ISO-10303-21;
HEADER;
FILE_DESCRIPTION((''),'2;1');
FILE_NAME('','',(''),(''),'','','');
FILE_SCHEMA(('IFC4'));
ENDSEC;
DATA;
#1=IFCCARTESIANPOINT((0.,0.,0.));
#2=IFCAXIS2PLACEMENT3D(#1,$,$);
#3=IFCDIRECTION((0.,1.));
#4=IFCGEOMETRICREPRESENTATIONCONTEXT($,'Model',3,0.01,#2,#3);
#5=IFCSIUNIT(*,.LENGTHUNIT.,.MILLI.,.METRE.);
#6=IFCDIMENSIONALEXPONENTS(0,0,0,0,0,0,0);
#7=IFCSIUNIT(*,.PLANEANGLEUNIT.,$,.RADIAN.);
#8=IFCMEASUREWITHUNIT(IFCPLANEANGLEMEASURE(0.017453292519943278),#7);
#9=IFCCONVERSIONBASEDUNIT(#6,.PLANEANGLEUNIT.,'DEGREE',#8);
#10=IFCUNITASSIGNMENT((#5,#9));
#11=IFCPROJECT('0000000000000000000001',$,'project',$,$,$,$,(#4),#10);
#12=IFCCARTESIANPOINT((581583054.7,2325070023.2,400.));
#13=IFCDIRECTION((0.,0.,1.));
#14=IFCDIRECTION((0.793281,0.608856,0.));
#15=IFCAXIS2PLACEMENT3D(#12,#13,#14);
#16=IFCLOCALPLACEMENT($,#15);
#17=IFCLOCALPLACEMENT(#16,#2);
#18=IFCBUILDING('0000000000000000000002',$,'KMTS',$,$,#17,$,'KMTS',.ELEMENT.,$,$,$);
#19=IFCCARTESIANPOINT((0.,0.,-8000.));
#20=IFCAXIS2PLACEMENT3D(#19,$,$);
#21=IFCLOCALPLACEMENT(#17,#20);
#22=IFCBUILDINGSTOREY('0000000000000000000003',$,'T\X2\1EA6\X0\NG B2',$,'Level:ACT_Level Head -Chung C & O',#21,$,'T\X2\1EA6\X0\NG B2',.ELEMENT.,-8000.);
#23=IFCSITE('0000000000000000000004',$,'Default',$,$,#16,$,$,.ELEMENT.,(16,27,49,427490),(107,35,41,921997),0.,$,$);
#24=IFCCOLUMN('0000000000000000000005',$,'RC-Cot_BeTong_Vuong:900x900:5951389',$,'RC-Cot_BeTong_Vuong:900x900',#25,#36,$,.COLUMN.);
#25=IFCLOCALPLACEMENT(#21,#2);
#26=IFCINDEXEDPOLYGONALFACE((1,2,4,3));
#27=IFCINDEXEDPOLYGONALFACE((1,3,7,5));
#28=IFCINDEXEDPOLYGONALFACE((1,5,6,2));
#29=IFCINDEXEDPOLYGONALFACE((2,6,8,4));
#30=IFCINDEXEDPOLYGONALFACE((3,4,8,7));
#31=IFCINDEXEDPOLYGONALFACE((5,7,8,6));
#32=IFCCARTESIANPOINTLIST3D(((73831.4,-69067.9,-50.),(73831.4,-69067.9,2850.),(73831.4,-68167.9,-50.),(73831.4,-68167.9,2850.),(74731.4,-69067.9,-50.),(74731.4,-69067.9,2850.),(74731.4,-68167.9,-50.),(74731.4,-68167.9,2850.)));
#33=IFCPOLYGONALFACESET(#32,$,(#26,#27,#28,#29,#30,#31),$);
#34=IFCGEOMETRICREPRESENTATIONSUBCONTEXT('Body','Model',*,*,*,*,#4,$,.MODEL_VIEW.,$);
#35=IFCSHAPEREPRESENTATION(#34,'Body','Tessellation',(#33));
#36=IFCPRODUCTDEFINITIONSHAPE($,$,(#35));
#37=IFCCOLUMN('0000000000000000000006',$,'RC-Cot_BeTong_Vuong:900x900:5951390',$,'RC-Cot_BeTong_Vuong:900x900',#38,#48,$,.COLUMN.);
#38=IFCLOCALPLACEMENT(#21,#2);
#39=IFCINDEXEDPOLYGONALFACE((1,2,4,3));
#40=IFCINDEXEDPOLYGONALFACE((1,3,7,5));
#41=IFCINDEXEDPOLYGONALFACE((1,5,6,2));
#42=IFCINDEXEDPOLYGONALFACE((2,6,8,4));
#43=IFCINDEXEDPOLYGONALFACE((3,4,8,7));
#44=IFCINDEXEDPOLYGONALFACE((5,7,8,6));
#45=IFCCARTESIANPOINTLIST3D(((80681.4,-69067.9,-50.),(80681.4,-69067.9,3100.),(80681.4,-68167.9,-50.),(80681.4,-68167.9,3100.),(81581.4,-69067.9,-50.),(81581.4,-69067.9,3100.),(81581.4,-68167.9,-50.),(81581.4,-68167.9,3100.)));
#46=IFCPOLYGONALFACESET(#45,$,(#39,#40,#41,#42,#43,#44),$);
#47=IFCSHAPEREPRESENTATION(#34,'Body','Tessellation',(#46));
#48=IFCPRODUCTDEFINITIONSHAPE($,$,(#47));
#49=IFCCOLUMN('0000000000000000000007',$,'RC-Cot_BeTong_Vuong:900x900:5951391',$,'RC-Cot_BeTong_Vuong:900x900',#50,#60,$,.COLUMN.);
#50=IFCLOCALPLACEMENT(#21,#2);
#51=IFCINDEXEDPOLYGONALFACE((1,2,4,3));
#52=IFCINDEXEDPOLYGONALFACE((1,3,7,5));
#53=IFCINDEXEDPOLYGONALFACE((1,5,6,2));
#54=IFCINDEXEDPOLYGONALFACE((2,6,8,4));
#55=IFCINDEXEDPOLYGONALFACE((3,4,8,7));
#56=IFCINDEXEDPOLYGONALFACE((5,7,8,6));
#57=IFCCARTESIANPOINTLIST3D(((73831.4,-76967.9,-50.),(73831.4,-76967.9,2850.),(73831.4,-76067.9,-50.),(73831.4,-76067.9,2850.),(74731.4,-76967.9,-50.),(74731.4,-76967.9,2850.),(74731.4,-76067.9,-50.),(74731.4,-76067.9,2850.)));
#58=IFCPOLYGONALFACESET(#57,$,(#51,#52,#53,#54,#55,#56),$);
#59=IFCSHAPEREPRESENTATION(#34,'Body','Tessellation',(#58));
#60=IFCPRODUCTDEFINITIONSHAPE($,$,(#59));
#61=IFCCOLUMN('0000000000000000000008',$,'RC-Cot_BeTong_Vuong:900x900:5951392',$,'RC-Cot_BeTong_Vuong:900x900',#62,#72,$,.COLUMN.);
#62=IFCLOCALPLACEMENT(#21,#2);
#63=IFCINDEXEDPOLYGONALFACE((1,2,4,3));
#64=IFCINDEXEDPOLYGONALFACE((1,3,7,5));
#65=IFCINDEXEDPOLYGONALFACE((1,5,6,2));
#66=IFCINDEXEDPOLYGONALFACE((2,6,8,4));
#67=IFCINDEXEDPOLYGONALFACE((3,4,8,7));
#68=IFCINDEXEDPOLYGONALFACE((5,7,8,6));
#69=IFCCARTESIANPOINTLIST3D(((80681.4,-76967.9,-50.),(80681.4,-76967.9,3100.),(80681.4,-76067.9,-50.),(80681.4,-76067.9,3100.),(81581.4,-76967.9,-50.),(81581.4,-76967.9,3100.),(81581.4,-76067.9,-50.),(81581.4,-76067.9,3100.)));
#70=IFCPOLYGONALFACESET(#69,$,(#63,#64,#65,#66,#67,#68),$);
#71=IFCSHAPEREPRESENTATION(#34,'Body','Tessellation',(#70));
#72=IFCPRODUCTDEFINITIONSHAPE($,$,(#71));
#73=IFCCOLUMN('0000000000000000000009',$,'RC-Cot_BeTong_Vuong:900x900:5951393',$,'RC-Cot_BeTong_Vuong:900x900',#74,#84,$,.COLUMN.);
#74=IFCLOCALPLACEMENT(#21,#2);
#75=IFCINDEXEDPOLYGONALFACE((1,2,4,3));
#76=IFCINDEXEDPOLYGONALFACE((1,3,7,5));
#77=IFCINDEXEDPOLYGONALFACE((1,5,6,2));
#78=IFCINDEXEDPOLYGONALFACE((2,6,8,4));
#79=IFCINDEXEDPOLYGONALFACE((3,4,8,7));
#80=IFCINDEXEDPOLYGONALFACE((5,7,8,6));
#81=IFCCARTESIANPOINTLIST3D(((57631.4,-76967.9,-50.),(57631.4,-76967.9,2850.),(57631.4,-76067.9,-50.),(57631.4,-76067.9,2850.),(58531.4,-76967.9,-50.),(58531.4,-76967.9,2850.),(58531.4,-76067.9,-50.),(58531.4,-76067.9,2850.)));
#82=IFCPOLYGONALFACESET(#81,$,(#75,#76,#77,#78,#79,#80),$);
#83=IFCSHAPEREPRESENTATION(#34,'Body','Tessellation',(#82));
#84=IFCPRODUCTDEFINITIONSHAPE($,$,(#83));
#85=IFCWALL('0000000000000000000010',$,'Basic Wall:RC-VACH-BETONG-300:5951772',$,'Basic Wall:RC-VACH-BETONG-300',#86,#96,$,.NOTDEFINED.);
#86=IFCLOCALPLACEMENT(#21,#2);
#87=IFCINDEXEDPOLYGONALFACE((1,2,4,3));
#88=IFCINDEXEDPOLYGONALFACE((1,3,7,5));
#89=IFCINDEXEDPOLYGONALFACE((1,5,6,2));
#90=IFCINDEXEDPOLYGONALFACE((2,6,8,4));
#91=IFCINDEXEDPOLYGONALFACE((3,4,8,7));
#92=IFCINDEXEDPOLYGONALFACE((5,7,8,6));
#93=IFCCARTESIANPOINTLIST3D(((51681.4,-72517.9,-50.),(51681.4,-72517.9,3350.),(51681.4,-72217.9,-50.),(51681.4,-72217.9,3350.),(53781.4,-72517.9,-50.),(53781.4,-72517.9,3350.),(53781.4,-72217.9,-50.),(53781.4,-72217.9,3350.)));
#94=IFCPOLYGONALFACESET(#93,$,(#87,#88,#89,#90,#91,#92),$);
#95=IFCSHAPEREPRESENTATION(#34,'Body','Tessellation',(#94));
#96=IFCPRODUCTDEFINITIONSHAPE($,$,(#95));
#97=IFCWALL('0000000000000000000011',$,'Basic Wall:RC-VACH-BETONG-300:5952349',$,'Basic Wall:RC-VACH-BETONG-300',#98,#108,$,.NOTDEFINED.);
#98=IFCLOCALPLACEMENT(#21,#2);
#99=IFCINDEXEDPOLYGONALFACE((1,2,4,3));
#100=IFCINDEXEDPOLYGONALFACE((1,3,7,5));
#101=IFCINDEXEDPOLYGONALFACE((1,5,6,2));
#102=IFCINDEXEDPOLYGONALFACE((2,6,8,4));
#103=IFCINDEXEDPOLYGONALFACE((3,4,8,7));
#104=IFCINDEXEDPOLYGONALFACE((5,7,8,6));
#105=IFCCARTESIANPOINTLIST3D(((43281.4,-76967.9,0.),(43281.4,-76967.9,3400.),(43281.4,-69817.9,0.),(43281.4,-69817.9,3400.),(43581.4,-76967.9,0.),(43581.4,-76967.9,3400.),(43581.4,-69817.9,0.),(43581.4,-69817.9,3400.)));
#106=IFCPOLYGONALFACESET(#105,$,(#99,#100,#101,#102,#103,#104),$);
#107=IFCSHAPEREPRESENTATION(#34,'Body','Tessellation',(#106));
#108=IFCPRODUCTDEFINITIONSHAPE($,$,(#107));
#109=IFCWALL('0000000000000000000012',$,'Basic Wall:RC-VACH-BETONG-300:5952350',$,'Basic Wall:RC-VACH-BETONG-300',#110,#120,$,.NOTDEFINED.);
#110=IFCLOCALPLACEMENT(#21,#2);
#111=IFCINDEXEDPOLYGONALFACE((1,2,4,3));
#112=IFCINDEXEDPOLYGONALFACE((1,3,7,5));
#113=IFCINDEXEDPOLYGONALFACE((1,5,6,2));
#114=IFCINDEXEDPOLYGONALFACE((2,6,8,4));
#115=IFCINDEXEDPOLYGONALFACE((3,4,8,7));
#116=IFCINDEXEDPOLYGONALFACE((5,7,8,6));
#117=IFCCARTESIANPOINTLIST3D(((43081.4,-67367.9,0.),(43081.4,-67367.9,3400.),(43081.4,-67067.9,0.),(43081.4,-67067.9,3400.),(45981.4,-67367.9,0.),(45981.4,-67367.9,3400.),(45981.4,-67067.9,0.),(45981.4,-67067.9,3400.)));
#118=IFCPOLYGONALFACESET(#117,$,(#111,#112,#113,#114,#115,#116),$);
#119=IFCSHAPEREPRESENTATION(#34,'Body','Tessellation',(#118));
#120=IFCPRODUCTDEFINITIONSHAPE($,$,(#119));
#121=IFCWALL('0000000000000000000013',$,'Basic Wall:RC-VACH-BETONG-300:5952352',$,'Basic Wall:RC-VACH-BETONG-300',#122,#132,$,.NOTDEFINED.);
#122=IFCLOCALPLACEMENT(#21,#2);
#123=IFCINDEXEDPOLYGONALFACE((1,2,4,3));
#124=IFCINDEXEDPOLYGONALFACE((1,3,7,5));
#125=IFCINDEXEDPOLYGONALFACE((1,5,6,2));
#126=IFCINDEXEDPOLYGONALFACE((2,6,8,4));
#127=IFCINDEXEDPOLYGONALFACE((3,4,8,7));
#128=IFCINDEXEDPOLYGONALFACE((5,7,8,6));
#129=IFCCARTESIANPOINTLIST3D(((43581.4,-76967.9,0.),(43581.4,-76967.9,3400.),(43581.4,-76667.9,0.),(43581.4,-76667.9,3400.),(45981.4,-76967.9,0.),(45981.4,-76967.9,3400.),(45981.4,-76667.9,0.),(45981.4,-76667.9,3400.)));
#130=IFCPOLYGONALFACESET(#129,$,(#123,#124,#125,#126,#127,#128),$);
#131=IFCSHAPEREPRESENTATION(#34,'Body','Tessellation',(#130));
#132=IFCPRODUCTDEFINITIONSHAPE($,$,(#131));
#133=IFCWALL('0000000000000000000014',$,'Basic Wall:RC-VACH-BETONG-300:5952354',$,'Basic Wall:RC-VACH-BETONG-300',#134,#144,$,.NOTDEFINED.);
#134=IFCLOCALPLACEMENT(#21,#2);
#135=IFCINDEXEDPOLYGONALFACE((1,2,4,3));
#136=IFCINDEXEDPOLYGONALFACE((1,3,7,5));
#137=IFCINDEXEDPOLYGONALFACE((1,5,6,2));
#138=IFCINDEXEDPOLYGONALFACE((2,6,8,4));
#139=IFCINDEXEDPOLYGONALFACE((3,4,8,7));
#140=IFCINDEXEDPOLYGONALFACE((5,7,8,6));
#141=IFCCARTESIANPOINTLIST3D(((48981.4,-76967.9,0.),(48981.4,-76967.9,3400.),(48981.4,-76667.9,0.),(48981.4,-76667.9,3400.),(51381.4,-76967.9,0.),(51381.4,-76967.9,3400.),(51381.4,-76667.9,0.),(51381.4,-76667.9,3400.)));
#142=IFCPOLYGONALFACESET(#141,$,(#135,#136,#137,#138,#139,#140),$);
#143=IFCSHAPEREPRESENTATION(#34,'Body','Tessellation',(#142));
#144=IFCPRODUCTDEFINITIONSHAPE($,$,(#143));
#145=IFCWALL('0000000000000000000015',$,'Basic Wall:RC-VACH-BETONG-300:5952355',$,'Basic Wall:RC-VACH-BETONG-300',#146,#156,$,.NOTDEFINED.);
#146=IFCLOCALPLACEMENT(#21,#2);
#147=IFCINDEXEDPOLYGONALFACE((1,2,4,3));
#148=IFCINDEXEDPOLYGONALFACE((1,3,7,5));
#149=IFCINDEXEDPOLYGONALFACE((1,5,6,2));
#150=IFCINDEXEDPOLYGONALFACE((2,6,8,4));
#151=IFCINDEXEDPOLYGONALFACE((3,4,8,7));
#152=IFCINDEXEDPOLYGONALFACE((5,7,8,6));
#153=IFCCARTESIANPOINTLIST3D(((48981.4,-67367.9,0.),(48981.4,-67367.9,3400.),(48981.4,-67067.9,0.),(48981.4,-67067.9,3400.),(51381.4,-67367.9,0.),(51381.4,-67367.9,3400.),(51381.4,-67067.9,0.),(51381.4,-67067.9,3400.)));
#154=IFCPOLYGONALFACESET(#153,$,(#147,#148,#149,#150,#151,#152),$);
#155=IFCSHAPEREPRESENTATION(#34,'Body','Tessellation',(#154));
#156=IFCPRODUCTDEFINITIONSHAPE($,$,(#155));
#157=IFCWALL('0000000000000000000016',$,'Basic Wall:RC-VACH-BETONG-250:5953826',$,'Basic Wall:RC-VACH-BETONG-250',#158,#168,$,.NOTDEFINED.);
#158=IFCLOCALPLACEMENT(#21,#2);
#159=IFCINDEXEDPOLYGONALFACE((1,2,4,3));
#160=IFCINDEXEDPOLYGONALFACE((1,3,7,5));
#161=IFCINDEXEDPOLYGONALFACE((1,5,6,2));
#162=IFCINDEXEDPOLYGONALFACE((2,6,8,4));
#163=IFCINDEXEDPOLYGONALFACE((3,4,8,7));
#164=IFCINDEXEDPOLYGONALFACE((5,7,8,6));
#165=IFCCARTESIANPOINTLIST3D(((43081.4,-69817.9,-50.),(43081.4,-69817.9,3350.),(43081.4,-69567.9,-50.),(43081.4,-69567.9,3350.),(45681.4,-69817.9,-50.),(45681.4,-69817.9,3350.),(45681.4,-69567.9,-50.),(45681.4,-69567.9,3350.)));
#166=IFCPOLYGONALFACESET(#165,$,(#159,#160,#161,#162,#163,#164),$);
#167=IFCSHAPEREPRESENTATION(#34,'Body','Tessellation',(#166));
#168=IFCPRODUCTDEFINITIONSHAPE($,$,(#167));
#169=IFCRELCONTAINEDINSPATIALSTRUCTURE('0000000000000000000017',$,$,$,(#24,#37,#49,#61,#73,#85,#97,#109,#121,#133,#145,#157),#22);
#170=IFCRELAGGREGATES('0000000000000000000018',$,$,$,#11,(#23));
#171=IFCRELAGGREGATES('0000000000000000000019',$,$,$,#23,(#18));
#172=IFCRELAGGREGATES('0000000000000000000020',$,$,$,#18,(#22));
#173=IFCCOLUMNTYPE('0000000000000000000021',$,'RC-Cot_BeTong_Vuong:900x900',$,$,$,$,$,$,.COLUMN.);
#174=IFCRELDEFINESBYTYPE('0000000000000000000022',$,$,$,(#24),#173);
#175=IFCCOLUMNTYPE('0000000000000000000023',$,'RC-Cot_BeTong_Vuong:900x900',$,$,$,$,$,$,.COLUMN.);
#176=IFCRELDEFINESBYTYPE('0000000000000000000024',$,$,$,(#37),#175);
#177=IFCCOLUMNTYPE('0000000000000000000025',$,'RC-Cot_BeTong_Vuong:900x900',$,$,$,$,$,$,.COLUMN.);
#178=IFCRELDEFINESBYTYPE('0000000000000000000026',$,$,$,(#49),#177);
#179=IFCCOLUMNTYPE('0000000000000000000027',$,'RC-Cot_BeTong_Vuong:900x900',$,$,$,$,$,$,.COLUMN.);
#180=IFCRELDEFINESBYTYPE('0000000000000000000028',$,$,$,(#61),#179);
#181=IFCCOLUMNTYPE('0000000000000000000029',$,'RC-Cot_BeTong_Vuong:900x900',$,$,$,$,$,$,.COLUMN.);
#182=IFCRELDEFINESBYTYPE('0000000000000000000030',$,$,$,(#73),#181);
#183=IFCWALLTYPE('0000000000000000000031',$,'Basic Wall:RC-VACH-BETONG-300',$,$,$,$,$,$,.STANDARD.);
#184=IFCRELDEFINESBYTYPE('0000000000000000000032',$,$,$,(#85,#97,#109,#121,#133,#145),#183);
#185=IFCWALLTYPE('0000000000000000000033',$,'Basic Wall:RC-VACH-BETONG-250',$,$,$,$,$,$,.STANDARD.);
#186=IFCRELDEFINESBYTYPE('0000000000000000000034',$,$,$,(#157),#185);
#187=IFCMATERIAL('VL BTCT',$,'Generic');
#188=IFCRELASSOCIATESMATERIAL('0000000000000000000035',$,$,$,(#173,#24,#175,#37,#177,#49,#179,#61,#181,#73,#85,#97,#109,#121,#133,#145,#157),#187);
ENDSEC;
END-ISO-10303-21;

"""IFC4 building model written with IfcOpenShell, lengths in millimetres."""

from ifc_helpers import new_model, entity, si_unit, converted_unit, direction, frame, origin, place, context, subcontext, project, spatial, indexed_curve, outline, extrude, source, transform, mapped, material, type_object, type_shapes, element, save


model = new_model("IFC4")

# Units and contexts
model_context = context("Model", 3, precision=0.01, world=origin(), true_north=direction((0.0, 1.0)))
body_context = subcontext(model_context, "Body", "Model", "MODEL_VIEW")
ifc_project = project(units=[si_unit("LENGTHUNIT", "METRE", prefix="MILLI"), converted_unit("PLANEANGLEUNIT", "DEGREE", entity("IfcPlaneAngleMeasure", 0.017453292519943278), si_unit("PLANEANGLEUNIT", "RADIAN"), dimensions=[0, 0, 0, 0, 0, 0, 0])], contexts=[model_context])

# Site, building, storey
site_placement = place(None, frame((581583054.7, 2325070023.2, 400.0), z_axis=(0.0, 0.0, 1.0), x_axis=(0.793281, 0.608856, 0.0)))
site = spatial("IfcSite", under=ifc_project, at=site_placement, Name="Default", CompositionType="ELEMENT", RefLatitude=(16, 27, 49, 427490), RefLongitude=(107, 35, 41, 921997), RefElevation=0.0)
building_placement = place(site_placement, origin())
building = spatial("IfcBuilding", under=site, at=building_placement, Name="KMTS", LongName="KMTS", CompositionType="ELEMENT")
storey_placement = place(building_placement, frame((0.0, 0.0, -8000.0)))
storey = spatial("IfcBuildingStorey", under=building, at=storey_placement, Name="TẦNG B2", ObjectType="Level:ACT_Level Head -Chung C & O", LongName="TẦNG B2", CompositionType="ELEMENT", Elevation=-8000.0)

# Columns
ifc_material = material(Name="VL BTCT", Category="Generic")
column_type_1 = type_object("IfcColumnType", Name="RC-Cot_BeTong_Vuong:900x900", PredefinedType="COLUMN", material=ifc_material)
shared_shape_1 = source(origin(), body_context, "Body", "SweptSolid", [
    extrude(outline(indexed_curve([(-450.0, -450.0), (450.0, -450.0), (450.0, 450.0), (-450.0, 450.0), (-450.0, -450.0)], self_intersect=False)), frame((74281.4, -68617.9, -8050.0), z_axis=(0.0, 0.0, 1.0), x_axis=(-1.0, 0.0, 0.0)), (0.0, 0.0, 1.0), 2900.0),
])
type_shapes(column_type_1, [shared_shape_1])
column_1_placement = place(storey_placement, frame((0.0, 0.0, 8000.0)))
element("IfcColumn", 1, at=column_1_placement, inside=storey, type_object=column_type_1, material=ifc_material, Name="RC-Cot_BeTong_Vuong:900x900:5951389", ObjectType="RC-Cot_BeTong_Vuong:900x900", PredefinedType="COLUMN", context=body_context, shape_type="MappedRepresentation", body=[
    mapped(shared_shape_1, transform((0.0, 0.0, 0.0), scale=1.0)),
])
column_type_2 = type_object("IfcColumnType", Name="RC-Cot_BeTong_Vuong:900x900", PredefinedType="COLUMN", material=ifc_material)
shared_shape_2 = source(origin(), body_context, "Body", "SweptSolid", [
    extrude(outline(indexed_curve([(-450.0, -450.0), (450.0, -450.0), (450.0, 450.0), (-450.0, 450.0), (-450.0, -450.0)], self_intersect=False)), frame((81131.4, -68617.9, -8050.0), z_axis=(0.0, 0.0, 1.0), x_axis=(-1.0, 0.0, 0.0)), (0.0, 0.0, 1.0), 3150.0),
])
type_shapes(column_type_2, [shared_shape_2])
column_2_placement = place(storey_placement, frame((0.0, 0.0, 8000.0)))
element("IfcColumn", 2, at=column_2_placement, inside=storey, type_object=column_type_2, material=ifc_material, Name="RC-Cot_BeTong_Vuong:900x900:5951390", ObjectType="RC-Cot_BeTong_Vuong:900x900", PredefinedType="COLUMN", context=body_context, shape_type="MappedRepresentation", body=[
    mapped(shared_shape_2, transform((0.0, 0.0, 0.0), scale=1.0)),
])
column_type_3 = type_object("IfcColumnType", Name="RC-Cot_BeTong_Vuong:900x900", PredefinedType="COLUMN", material=ifc_material)
shared_shape_3 = source(origin(), body_context, "Body", "SweptSolid", [
    extrude(outline(indexed_curve([(-450.0, -450.0), (450.0, -450.0), (450.0, 450.0), (-450.0, 450.0), (-450.0, -450.0)], self_intersect=False)), frame((74281.4, -76517.9, -8050.0), z_axis=(0.0, 0.0, 1.0), x_axis=(-1.0, 0.0, 0.0)), (0.0, 0.0, 1.0), 2900.0),
])
type_shapes(column_type_3, [shared_shape_3])
column_3_placement = place(storey_placement, frame((0.0, 0.0, 8000.0)))
element("IfcColumn", 3, at=column_3_placement, inside=storey, type_object=column_type_3, material=ifc_material, Name="RC-Cot_BeTong_Vuong:900x900:5951391", ObjectType="RC-Cot_BeTong_Vuong:900x900", PredefinedType="COLUMN", context=body_context, shape_type="MappedRepresentation", body=[
    mapped(shared_shape_3, transform((0.0, 0.0, 0.0), scale=1.0)),
])
column_type_4 = type_object("IfcColumnType", Name="RC-Cot_BeTong_Vuong:900x900", PredefinedType="COLUMN", material=ifc_material)
shared_shape_4 = source(origin(), body_context, "Body", "SweptSolid", [
    extrude(outline(indexed_curve([(-450.0, -450.0), (450.0, -450.0), (450.0, 450.0), (-450.0, 450.0), (-450.0, -450.0)], self_intersect=False)), frame((81131.4, -76517.9, -8050.0), z_axis=(0.0, 0.0, 1.0), x_axis=(-1.0, 0.0, 0.0)), (0.0, 0.0, 1.0), 3150.0),
])
type_shapes(column_type_4, [shared_shape_4])
column_4_placement = place(storey_placement, frame((0.0, 0.0, 8000.0)))
element("IfcColumn", 4, at=column_4_placement, inside=storey, type_object=column_type_4, material=ifc_material, Name="RC-Cot_BeTong_Vuong:900x900:5951392", ObjectType="RC-Cot_BeTong_Vuong:900x900", PredefinedType="COLUMN", context=body_context, shape_type="MappedRepresentation", body=[
    mapped(shared_shape_4, transform((0.0, 0.0, 0.0), scale=1.0)),
])
column_type_5 = type_object("IfcColumnType", Name="RC-Cot_BeTong_Vuong:900x900", PredefinedType="COLUMN", material=ifc_material)
shared_shape_5 = source(origin(), body_context, "Body", "SweptSolid", [
    extrude(outline(indexed_curve([(-450.0, -450.0), (450.0, -450.0), (450.0, 450.0), (-450.0, 450.0), (-450.0, -450.0)], self_intersect=False)), frame((58081.4, -76517.9, -8050.0), z_axis=(0.0, 0.0, 1.0), x_axis=(-1.0, 0.0, 0.0)), (0.0, 0.0, 1.0), 2900.0),
])
type_shapes(column_type_5, [shared_shape_5])
column_5_placement = place(storey_placement, frame((0.0, 0.0, 8000.0)))
element("IfcColumn", 5, at=column_5_placement, inside=storey, type_object=column_type_5, material=ifc_material, Name="RC-Cot_BeTong_Vuong:900x900:5951393", ObjectType="RC-Cot_BeTong_Vuong:900x900", PredefinedType="COLUMN", context=body_context, shape_type="MappedRepresentation", body=[
    mapped(shared_shape_5, transform((0.0, 0.0, 0.0), scale=1.0)),
])

# Walls
wall_type_1 = type_object("IfcWallType", Name="Basic Wall:RC-VACH-BETONG-300", PredefinedType="STANDARD")
wall_1_placement = place(storey_placement, frame((53781.4, -72367.9, -50.0), z_axis=(0.0, 0.0, 1.0), x_axis=(-1.0, 0.0, 0.0)))
element("IfcWall", 6, at=wall_1_placement, inside=storey, type_object=wall_type_1, material=ifc_material, Name="Basic Wall:RC-VACH-BETONG-300:5951772", ObjectType="Basic Wall:RC-VACH-BETONG-300", PredefinedType="NOTDEFINED", context=body_context, shape_type="SweptSolid", body=[
    extrude(outline(indexed_curve([(2100.0, 150.0), (0.0, 150.0), (0.0, -150.0), (2100.0, -150.0), (2100.0, 150.0)], self_intersect=False)), origin(), (0.0, 0.0, 1.0), 3400.0),
])
wall_2_placement = place(storey_placement, frame((43431.4, -69817.9, 0.0), z_axis=(0.0, 0.0, 1.0), x_axis=(0.0, -1.0, 0.0)))
element("IfcWall", 7, at=wall_2_placement, inside=storey, type_object=wall_type_1, material=ifc_material, Name="Basic Wall:RC-VACH-BETONG-300:5952349", ObjectType="Basic Wall:RC-VACH-BETONG-300", PredefinedType="NOTDEFINED", context=body_context, shape_type="SweptSolid", body=[
    extrude(outline(indexed_curve([(7150.0, 150.0), (0.0, 150.0), (0.0, -150.0), (7150.0, -150.0), (7150.0, 150.0)], self_intersect=False)), origin(), (0.0, 0.0, 1.0), 3400.0),
])
wall_3_placement = place(storey_placement, frame((45981.4, -67217.9, 0.0), z_axis=(0.0, 0.0, 1.0), x_axis=(-1.0, 0.0, 0.0)))
element("IfcWall", 8, at=wall_3_placement, inside=storey, type_object=wall_type_1, material=ifc_material, Name="Basic Wall:RC-VACH-BETONG-300:5952350", ObjectType="Basic Wall:RC-VACH-BETONG-300", PredefinedType="NOTDEFINED", context=body_context, shape_type="SweptSolid", body=[
    extrude(outline(indexed_curve([(2900.0, 150.0), (0.0, 150.0), (0.0, -150.0), (2900.0, -150.0), (2900.0, 150.0)], self_intersect=False)), origin(), (0.0, 0.0, 1.0), 3400.0),
])
wall_4_placement = place(storey_placement, frame((45981.4, -76817.9, 0.0), z_axis=(0.0, 0.0, 1.0), x_axis=(-1.0, 0.0, 0.0)))
element("IfcWall", 9, at=wall_4_placement, inside=storey, type_object=wall_type_1, material=ifc_material, Name="Basic Wall:RC-VACH-BETONG-300:5952352", ObjectType="Basic Wall:RC-VACH-BETONG-300", PredefinedType="NOTDEFINED", context=body_context, shape_type="SweptSolid", body=[
    extrude(outline(indexed_curve([(2400.0, 150.0), (0.0, 150.0), (0.0, -150.0), (2400.0, -150.0), (2400.0, 150.0)], self_intersect=False)), origin(), (0.0, 0.0, 1.0), 3400.0),
])
wall_5_placement = place(storey_placement, frame((51381.4, -76817.9, 0.0), z_axis=(0.0, 0.0, 1.0), x_axis=(-1.0, 0.0, 0.0)))
element("IfcWall", 10, at=wall_5_placement, inside=storey, type_object=wall_type_1, material=ifc_material, Name="Basic Wall:RC-VACH-BETONG-300:5952354", ObjectType="Basic Wall:RC-VACH-BETONG-300", PredefinedType="NOTDEFINED", context=body_context, shape_type="SweptSolid", body=[
    extrude(outline(indexed_curve([(2400.0, 150.0), (0.0, 150.0), (0.0, -150.0), (2400.0, -150.0), (2400.0, 150.0)], self_intersect=False)), origin(), (0.0, 0.0, 1.0), 3400.0),
])
wall_6_placement = place(storey_placement, frame((51381.4, -67217.9, 0.0), z_axis=(0.0, 0.0, 1.0), x_axis=(-1.0, 0.0, 0.0)))
element("IfcWall", 11, at=wall_6_placement, inside=storey, type_object=wall_type_1, material=ifc_material, Name="Basic Wall:RC-VACH-BETONG-300:5952355", ObjectType="Basic Wall:RC-VACH-BETONG-300", PredefinedType="NOTDEFINED", context=body_context, shape_type="SweptSolid", body=[
    extrude(outline(indexed_curve([(2400.0, 150.0), (0.0, 150.0), (0.0, -150.0), (2400.0, -150.0), (2400.0, 150.0)], self_intersect=False)), origin(), (0.0, 0.0, 1.0), 3400.0),
])
wall_type_2 = type_object("IfcWallType", Name="Basic Wall:RC-VACH-BETONG-250", PredefinedType="STANDARD")
wall_7_placement = place(storey_placement, frame((45681.4, -69692.9, -50.0), z_axis=(0.0, 0.0, 1.0), x_axis=(-1.0, 0.0, 0.0)))
element("IfcWall", 12, at=wall_7_placement, inside=storey, type_object=wall_type_2, material=ifc_material, Name="Basic Wall:RC-VACH-BETONG-250:5953826", ObjectType="Basic Wall:RC-VACH-BETONG-250", PredefinedType="NOTDEFINED", context=body_context, shape_type="SweptSolid", body=[
    extrude(outline(indexed_curve([(2600.0, 125.0), (0.0, 125.0), (0.0, -125.0), (2600.0, -125.0), (2600.0, 125.0)], self_intersect=False)), origin(), (0.0, 0.0, 1.0), 3400.0),
])

save(model, "model.ifc")
